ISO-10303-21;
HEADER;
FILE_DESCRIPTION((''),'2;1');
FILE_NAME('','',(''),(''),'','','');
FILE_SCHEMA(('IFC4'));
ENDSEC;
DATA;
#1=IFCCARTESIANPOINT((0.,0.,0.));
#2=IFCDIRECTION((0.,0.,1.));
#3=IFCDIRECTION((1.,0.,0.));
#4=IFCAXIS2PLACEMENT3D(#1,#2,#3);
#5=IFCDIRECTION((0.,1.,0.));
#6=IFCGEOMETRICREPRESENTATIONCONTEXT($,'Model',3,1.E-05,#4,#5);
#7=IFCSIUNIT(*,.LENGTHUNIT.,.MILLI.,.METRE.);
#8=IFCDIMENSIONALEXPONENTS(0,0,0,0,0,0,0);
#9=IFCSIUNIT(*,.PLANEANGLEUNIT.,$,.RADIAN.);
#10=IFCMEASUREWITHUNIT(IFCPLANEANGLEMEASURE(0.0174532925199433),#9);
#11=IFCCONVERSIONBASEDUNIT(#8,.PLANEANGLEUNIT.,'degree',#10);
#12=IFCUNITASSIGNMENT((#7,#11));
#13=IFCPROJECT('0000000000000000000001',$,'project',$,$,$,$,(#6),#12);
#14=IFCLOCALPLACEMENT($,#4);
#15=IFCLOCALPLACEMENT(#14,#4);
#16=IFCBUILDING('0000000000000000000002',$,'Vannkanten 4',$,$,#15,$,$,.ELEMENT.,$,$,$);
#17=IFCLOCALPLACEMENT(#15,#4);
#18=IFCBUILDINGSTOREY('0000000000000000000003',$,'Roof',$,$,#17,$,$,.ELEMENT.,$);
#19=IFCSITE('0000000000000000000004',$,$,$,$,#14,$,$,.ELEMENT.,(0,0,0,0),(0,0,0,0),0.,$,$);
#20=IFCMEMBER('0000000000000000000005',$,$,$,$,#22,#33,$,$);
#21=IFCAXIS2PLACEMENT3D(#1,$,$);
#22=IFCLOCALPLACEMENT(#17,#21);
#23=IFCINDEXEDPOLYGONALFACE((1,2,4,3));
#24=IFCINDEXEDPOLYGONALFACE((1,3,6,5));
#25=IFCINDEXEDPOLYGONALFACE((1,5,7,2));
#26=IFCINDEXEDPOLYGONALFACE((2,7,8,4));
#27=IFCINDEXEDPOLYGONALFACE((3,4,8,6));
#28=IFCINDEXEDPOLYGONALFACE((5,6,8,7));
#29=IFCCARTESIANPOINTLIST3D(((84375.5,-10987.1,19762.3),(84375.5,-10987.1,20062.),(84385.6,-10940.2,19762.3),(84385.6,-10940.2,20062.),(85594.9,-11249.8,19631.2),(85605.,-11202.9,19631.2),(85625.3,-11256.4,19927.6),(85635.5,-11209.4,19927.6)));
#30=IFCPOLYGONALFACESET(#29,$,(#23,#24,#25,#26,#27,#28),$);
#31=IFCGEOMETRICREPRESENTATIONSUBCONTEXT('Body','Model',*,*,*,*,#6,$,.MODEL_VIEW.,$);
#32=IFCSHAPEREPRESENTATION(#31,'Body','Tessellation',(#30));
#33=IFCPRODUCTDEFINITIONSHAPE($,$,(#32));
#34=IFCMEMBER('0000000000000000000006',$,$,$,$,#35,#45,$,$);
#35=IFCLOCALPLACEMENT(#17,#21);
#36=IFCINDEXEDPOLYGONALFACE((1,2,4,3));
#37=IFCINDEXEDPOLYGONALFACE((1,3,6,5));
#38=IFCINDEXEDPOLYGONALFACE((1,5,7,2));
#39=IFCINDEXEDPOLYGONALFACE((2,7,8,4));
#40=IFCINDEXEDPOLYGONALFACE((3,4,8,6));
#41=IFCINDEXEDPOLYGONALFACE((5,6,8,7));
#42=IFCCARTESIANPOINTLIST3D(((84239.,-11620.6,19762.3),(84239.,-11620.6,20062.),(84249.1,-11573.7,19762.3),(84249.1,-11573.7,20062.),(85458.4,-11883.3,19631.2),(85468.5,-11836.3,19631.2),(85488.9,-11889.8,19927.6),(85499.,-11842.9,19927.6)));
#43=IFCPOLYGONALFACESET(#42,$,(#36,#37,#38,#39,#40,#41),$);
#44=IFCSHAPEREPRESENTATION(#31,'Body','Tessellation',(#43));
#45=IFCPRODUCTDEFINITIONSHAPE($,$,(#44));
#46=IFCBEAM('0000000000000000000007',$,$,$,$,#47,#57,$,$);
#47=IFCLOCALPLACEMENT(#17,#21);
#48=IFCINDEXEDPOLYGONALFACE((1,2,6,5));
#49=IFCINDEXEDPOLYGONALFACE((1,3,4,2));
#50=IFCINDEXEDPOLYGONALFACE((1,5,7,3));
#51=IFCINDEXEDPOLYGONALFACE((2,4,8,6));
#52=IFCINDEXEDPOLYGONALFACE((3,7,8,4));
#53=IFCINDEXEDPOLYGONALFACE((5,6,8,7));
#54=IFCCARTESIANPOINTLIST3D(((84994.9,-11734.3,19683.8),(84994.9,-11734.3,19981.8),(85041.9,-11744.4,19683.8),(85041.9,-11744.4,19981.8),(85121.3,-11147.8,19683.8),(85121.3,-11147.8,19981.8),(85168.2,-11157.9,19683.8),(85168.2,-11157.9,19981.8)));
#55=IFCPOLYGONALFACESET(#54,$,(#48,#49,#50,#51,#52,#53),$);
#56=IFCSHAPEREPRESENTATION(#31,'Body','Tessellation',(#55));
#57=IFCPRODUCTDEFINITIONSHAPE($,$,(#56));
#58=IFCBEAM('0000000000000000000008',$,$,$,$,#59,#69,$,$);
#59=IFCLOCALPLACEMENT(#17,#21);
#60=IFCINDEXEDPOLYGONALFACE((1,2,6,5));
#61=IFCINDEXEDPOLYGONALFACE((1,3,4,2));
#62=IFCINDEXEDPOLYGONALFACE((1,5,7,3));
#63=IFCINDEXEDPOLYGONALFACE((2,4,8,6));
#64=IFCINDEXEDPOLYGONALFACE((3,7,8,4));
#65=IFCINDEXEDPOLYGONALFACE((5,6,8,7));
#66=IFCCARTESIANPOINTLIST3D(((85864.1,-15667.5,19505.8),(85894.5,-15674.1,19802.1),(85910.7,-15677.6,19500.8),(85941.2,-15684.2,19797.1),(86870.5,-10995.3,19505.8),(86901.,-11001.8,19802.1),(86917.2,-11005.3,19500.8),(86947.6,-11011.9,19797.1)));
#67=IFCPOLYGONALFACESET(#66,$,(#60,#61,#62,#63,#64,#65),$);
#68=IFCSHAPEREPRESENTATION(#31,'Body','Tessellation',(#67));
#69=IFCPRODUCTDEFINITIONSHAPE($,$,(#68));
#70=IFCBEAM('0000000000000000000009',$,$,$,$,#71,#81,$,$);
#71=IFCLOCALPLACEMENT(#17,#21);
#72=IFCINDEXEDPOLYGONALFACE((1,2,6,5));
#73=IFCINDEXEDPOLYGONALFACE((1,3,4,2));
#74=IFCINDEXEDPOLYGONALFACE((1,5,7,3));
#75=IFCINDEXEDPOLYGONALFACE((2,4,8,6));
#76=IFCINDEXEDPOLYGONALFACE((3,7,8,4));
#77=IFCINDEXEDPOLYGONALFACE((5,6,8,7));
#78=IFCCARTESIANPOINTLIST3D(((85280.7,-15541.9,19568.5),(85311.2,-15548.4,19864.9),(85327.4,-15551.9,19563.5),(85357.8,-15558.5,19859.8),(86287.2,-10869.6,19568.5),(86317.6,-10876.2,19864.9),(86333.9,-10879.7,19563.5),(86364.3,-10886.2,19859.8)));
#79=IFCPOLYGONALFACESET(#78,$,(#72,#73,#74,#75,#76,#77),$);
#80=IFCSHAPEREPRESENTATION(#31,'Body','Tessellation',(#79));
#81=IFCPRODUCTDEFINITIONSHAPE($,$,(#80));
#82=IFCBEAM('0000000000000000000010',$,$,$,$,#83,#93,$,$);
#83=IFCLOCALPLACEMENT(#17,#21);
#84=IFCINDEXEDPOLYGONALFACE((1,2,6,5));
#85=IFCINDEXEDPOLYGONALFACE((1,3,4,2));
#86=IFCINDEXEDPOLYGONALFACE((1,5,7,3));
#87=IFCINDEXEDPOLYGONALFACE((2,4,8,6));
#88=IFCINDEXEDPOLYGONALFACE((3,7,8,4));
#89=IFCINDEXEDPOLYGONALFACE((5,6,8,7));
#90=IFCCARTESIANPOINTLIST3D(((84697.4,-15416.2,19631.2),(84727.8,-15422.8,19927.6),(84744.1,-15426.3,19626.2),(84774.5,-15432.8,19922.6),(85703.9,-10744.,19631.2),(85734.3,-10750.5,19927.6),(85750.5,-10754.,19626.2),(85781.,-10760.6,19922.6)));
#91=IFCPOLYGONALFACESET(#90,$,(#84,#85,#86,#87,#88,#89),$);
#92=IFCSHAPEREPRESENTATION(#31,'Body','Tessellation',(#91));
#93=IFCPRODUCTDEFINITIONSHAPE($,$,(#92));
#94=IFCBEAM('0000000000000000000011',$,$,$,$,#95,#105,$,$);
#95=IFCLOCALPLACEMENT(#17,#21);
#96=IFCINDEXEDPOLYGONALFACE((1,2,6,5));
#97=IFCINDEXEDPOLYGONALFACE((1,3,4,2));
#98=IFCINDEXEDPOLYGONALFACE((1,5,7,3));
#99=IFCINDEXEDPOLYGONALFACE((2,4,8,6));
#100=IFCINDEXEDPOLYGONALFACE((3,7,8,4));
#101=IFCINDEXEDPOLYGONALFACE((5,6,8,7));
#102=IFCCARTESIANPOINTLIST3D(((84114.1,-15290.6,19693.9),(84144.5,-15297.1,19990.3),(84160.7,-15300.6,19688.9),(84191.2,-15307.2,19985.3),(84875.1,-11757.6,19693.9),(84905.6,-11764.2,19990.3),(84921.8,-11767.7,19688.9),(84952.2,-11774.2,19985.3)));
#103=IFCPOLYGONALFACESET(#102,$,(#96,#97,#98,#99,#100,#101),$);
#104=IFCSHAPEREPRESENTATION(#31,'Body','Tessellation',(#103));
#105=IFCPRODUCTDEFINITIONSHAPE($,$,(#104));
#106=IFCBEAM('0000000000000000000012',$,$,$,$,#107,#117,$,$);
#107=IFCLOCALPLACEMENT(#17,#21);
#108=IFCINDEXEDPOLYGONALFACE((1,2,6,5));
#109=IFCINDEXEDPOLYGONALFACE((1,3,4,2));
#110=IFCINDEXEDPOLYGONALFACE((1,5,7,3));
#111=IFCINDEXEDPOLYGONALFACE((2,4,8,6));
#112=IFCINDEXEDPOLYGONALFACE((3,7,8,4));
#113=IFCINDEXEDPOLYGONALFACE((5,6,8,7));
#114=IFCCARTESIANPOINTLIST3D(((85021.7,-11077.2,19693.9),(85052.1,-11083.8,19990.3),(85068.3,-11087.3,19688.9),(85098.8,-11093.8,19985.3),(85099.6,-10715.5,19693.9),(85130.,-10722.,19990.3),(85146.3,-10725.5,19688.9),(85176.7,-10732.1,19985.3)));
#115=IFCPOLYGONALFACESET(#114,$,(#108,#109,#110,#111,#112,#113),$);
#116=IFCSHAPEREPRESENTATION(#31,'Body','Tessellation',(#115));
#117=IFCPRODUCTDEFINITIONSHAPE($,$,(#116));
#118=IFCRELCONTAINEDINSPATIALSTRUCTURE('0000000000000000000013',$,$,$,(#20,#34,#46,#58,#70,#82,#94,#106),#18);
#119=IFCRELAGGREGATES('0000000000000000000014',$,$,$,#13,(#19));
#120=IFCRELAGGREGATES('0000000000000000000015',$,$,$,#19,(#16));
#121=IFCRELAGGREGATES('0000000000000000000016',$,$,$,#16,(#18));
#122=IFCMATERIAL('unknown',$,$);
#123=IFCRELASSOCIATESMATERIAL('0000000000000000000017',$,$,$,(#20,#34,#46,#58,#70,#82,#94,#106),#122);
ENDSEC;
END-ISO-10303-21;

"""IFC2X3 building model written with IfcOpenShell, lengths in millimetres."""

from ifc_helpers import new_model, entity, si_unit, converted_unit, direction, frame, origin_with_axes, place, context, subcontext, project, spatial, polyline, segment, composite_curve, outline, extrude, clip, halfspace, material, element, save


model = new_model("IFC2X3")

# Units and contexts
model_context = context("Model", 3, precision=1e-05, world=origin_with_axes(), true_north=direction((0.0, 1.0, 0.0)))
body_context = subcontext(model_context, "Body", "Model", "MODEL_VIEW")
ifc_project = project(units=[si_unit("LENGTHUNIT", "METRE", prefix="MILLI"), converted_unit("PLANEANGLEUNIT", "degree", entity("IfcPlaneAngleMeasure", 0.0174532925199433), si_unit("PLANEANGLEUNIT", "RADIAN"), dimensions=[0, 0, 0, 0, 0, 0, 0])], contexts=[model_context])

# Site, building, storey
site_placement = place(None, origin_with_axes())
site = spatial("IfcSite", under=ifc_project, at=site_placement, CompositionType="ELEMENT", RefLatitude=(0, 0, 0, 0), RefLongitude=(0, 0, 0, 0), RefElevation=0.0)
building_placement = place(site_placement, origin_with_axes())
building = spatial("IfcBuilding", under=site, at=building_placement, Name="Vannkanten 4", CompositionType="ELEMENT")
storey_placement = place(building_placement, origin_with_axes())
storey = spatial("IfcBuildingStorey", under=building, at=storey_placement, Name="Roof", CompositionType="ELEMENT")

# Shared definitions
ifc_material = material(Name="unknown")

# Members
member_1_placement = place(storey_placement, frame((85615.2, -11229.6, 19779.4), z_axis=(-0.972221, 0.209428, 0.104528), x_axis=(-0.210582, -0.977576, 0.0)))
element("IfcMember", 1, at=member_1_placement, inside=storey, material=ifc_material, context=body_context, shape_type="Clipping", body=[
    clip(extrude(outline(composite_curve([segment(polyline([(-24.0, -149.0), (-24.0, 149.0), (24.0, 149.0), (24.0, -149.0), (-24.0, -149.0)]), True, "CONTINUOUS")], self_intersect=False)), frame((0.0, 0.0, 0.0), z_axis=(0.0, 0.0, 1.0), x_axis=(1.0, 0.0, 0.0)), (0.0, 0.0, 1.0), 1928.4), halfspace(frame((-24.0, -149.0, 1254.3), z_axis=(0.0, 0.104528, -0.994522), x_axis=(0.0, -0.994522, -0.104528)), True)),
])
member_2_placement = place(storey_placement, frame((84244.0, -11597.1, 19912.1), z_axis=(0.972221, -0.209428, -0.104528), x_axis=(0.210582, 0.977576, 0.0)))
element("IfcMember", 2, at=member_2_placement, inside=storey, material=ifc_material, context=body_context, shape_type="Clipping", body=[
    clip(extrude(outline(composite_curve([segment(polyline([(-24.0, -149.0), (-24.0, 149.0), (24.0, 149.0), (24.0, -149.0), (-24.0, -149.0)]), True, "CONTINUOUS")], self_intersect=False)), frame((0.0, 0.0, -658.5), z_axis=(0.0, 0.0, 1.0), x_axis=(1.0, 0.0, 0.0)), (0.0, 0.0, 1.0), 1928.4), halfspace(frame((-24.0, 149.0, -15.7), z_axis=(0.0, 0.104528, 0.994522), x_axis=(0.0, 0.994522, -0.104528)), True)),
])

# Beams
beam_1_placement = place(storey_placement, frame((85018.4, -11739.4, 19832.8), z_axis=(0.210582, 0.977576, 0.0), x_axis=(-0.977576, 0.210582, 0.0)))
element("IfcBeam", 3, at=beam_1_placement, inside=storey, material=ifc_material, context=body_context, shape_type="SweptSolid", body=[
    extrude(outline(composite_curve([segment(polyline([(-24.0, -149.0), (-24.0, 149.0), (24.0, 149.0), (24.0, -149.0), (-24.0, -149.0)]), True, "CONTINUOUS")], self_intersect=False)), frame((0.0, 0.0, 0.0), z_axis=(0.0, 0.0, 1.0), x_axis=(1.0, 0.0, 0.0)), (0.0, 0.0, 1.0), 600.0),
])
beam_2_placement = place(storey_placement, frame((85902.6, -15675.8, 19651.4), z_axis=(0.210582, 0.977576, 0.0), x_axis=(-0.972221, 0.209428, 0.104528)))
element("IfcBeam", 4, at=beam_2_placement, inside=storey, material=ifc_material, context=body_context, shape_type="SweptSolid", body=[
    extrude(outline(composite_curve([segment(polyline([(-24.0, -149.0), (-24.0, 149.0), (24.0, 149.0), (24.0, -149.0), (-24.0, -149.0)]), True, "CONTINUOUS")], self_intersect=False)), frame((0.0, 0.0, 0.0), z_axis=(0.0, 0.0, 1.0), x_axis=(1.0, 0.0, 0.0)), (0.0, 0.0, 1.0), 4779.4),
])
beam_3_placement = place(storey_placement, frame((85319.3, -15550.2, 19714.2), z_axis=(0.210582, 0.977576, 0.0), x_axis=(-0.972221, 0.209428, 0.104528)))
element("IfcBeam", 5, at=beam_3_placement, inside=storey, material=ifc_material, context=body_context, shape_type="SweptSolid", body=[
    extrude(outline(composite_curve([segment(polyline([(-24.0, -149.0), (-24.0, 149.0), (24.0, 149.0), (24.0, -149.0), (-24.0, -149.0)]), True, "CONTINUOUS")], self_intersect=False)), frame((0.0, 0.0, 0.0), z_axis=(0.0, 0.0, 1.0), x_axis=(1.0, 0.0, 0.0)), (0.0, 0.0, 1.0), 4779.4),
])
beam_4_placement = place(storey_placement, frame((84736.0, -15424.5, 19776.9), z_axis=(0.210582, 0.977576, 0.0), x_axis=(-0.972221, 0.209428, 0.104528)))
element("IfcBeam", 6, at=beam_4_placement, inside=storey, material=ifc_material, context=body_context, shape_type="SweptSolid", body=[
    extrude(outline(composite_curve([segment(polyline([(-24.0, -149.0), (-24.0, 149.0), (24.0, 149.0), (24.0, -149.0), (-24.0, -149.0)]), True, "CONTINUOUS")], self_intersect=False)), frame((0.0, 0.0, 0.0), z_axis=(0.0, 0.0, 1.0), x_axis=(1.0, 0.0, 0.0)), (0.0, 0.0, 1.0), 4779.4),
])
beam_5_placement = place(storey_placement, frame((84152.6, -15298.9, 19839.6), z_axis=(0.210582, 0.977576, 0.0), x_axis=(-0.972221, 0.209428, 0.104528)))
element("IfcBeam", 7, at=beam_5_placement, inside=storey, material=ifc_material, context=body_context, shape_type="SweptSolid", body=[
    extrude(outline(composite_curve([segment(polyline([(-24.0, -149.0), (-24.0, 149.0), (24.0, 149.0), (24.0, -149.0), (-24.0, -149.0)]), True, "CONTINUOUS")], self_intersect=False)), frame((0.0, 0.0, 0.0), z_axis=(0.0, 0.0, 1.0), x_axis=(1.0, 0.0, 0.0)), (0.0, 0.0, 1.0), 3614.0),
])
beam_6_placement = place(storey_placement, frame((85060.2, -11085.5, 19839.6), z_axis=(0.210582, 0.977576, 0.0), x_axis=(-0.972221, 0.209428, 0.104528)))
element("IfcBeam", 8, at=beam_6_placement, inside=storey, material=ifc_material, context=body_context, shape_type="SweptSolid", body=[
    extrude(outline(composite_curve([segment(polyline([(-24.0, -149.0), (-24.0, 149.0), (24.0, 149.0), (24.0, -149.0), (-24.0, -149.0)]), True, "CONTINUOUS")], self_intersect=False)), frame((0.0, 0.0, 0.0), z_axis=(0.0, 0.0, 1.0), x_axis=(1.0, 0.0, 0.0)), (0.0, 0.0, 1.0), 370.0),
])

save(model, "model.ifc")
